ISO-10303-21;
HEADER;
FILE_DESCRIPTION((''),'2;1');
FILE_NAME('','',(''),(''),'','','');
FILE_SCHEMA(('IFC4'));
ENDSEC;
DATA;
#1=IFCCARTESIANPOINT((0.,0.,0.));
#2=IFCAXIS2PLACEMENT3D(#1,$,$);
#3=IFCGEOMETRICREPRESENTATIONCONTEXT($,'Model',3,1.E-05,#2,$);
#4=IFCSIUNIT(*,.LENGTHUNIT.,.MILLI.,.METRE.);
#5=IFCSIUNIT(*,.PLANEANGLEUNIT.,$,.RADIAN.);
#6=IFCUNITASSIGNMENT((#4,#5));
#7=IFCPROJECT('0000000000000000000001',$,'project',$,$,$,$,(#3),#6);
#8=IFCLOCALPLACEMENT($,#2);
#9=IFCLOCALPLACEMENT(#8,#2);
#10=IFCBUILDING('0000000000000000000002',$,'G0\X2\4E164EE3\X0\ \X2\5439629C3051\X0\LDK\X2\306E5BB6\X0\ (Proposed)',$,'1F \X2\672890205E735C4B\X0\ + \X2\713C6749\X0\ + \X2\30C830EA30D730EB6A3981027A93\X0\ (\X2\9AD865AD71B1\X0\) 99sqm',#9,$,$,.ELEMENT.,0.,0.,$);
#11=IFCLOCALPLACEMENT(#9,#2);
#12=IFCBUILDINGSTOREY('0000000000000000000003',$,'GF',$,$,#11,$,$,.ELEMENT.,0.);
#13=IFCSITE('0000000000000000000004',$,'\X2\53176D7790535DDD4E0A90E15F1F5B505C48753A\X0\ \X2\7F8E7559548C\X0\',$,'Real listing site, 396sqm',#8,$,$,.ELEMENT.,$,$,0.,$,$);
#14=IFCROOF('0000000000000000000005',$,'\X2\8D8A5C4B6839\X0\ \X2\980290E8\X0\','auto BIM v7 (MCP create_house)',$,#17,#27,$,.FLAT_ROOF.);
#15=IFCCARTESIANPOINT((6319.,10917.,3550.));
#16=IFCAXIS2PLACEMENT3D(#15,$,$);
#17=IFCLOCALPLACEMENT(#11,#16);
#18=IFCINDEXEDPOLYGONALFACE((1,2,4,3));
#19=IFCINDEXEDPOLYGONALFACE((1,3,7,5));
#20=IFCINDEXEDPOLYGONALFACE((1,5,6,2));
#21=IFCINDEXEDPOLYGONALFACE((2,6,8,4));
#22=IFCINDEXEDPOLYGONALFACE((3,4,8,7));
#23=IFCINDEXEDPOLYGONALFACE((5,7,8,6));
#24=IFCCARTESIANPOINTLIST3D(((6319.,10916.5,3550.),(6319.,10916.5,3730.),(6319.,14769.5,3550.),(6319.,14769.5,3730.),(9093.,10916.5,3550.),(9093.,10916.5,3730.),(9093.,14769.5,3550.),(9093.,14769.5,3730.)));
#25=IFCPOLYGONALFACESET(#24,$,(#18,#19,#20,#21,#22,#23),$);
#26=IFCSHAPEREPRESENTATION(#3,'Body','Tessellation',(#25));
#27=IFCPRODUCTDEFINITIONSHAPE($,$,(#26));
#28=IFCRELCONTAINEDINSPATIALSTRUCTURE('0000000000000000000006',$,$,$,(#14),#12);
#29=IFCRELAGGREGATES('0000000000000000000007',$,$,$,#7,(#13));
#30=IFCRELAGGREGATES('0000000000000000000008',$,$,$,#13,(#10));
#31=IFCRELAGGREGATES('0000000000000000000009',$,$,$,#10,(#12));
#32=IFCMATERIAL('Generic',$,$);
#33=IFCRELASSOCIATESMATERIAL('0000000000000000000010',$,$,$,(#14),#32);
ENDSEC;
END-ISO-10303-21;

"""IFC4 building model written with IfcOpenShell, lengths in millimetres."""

from ifc_helpers import new_model, si_unit, frame, frame_2d, origin, place, context, project, spatial, rectangle, extrude, material, element, save


model = new_model("IFC4")

# Units and contexts
model_context = context("Model", 3, precision=1e-05, world=origin())
ifc_project = project(units=[si_unit("LENGTHUNIT", "METRE", prefix="MILLI"), si_unit("PLANEANGLEUNIT", "RADIAN")], contexts=[model_context])

# Site, building, storey
site_placement = place(None, origin())
site = spatial("IfcSite", under=ifc_project, at=site_placement, Name="北海道川上郡弟子屈町 美留和", ObjectType="Real listing site, 396sqm", CompositionType="ELEMENT", RefElevation=0.0)
building_placement = place(site_placement, origin())
building = spatial("IfcBuilding", under=site, at=building_placement, Name="G0世代 吹抜けLDKの家 (Proposed)", ObjectType="1F 木造平屋 + 焼杉 + トリプル樹脂窓 (高断熱) 99sqm", CompositionType="ELEMENT", ElevationOfRefHeight=0.0, ElevationOfTerrain=0.0)
storey_placement = place(building_placement, origin())
storey = spatial("IfcBuildingStorey", under=building, at=storey_placement, Name="GF", CompositionType="ELEMENT", Elevation=0.0)

# Shared definitions
ifc_material = material(Name="Generic")

# Roof
roof_1_placement = place(storey_placement, frame((6319.0, 10917.0, 3550.0)))
element("IfcRoof", 1, at=roof_1_placement, inside=storey, material=ifc_material, Name="越屋根 頂部", Description="auto BIM v7 (MCP create_house)", PredefinedType="FLAT_ROOF", context=model_context, shape_type="SweptSolid", body=[
    extrude(rectangle(XDim=2774.0, YDim=3853.0, at=frame_2d((1387.0, 1926.0))), frame((6319.0, 10917.0, 3550.0)), (0.0, 0.0, 1.0), 180.0),
])

save(model, "model.ifc")
